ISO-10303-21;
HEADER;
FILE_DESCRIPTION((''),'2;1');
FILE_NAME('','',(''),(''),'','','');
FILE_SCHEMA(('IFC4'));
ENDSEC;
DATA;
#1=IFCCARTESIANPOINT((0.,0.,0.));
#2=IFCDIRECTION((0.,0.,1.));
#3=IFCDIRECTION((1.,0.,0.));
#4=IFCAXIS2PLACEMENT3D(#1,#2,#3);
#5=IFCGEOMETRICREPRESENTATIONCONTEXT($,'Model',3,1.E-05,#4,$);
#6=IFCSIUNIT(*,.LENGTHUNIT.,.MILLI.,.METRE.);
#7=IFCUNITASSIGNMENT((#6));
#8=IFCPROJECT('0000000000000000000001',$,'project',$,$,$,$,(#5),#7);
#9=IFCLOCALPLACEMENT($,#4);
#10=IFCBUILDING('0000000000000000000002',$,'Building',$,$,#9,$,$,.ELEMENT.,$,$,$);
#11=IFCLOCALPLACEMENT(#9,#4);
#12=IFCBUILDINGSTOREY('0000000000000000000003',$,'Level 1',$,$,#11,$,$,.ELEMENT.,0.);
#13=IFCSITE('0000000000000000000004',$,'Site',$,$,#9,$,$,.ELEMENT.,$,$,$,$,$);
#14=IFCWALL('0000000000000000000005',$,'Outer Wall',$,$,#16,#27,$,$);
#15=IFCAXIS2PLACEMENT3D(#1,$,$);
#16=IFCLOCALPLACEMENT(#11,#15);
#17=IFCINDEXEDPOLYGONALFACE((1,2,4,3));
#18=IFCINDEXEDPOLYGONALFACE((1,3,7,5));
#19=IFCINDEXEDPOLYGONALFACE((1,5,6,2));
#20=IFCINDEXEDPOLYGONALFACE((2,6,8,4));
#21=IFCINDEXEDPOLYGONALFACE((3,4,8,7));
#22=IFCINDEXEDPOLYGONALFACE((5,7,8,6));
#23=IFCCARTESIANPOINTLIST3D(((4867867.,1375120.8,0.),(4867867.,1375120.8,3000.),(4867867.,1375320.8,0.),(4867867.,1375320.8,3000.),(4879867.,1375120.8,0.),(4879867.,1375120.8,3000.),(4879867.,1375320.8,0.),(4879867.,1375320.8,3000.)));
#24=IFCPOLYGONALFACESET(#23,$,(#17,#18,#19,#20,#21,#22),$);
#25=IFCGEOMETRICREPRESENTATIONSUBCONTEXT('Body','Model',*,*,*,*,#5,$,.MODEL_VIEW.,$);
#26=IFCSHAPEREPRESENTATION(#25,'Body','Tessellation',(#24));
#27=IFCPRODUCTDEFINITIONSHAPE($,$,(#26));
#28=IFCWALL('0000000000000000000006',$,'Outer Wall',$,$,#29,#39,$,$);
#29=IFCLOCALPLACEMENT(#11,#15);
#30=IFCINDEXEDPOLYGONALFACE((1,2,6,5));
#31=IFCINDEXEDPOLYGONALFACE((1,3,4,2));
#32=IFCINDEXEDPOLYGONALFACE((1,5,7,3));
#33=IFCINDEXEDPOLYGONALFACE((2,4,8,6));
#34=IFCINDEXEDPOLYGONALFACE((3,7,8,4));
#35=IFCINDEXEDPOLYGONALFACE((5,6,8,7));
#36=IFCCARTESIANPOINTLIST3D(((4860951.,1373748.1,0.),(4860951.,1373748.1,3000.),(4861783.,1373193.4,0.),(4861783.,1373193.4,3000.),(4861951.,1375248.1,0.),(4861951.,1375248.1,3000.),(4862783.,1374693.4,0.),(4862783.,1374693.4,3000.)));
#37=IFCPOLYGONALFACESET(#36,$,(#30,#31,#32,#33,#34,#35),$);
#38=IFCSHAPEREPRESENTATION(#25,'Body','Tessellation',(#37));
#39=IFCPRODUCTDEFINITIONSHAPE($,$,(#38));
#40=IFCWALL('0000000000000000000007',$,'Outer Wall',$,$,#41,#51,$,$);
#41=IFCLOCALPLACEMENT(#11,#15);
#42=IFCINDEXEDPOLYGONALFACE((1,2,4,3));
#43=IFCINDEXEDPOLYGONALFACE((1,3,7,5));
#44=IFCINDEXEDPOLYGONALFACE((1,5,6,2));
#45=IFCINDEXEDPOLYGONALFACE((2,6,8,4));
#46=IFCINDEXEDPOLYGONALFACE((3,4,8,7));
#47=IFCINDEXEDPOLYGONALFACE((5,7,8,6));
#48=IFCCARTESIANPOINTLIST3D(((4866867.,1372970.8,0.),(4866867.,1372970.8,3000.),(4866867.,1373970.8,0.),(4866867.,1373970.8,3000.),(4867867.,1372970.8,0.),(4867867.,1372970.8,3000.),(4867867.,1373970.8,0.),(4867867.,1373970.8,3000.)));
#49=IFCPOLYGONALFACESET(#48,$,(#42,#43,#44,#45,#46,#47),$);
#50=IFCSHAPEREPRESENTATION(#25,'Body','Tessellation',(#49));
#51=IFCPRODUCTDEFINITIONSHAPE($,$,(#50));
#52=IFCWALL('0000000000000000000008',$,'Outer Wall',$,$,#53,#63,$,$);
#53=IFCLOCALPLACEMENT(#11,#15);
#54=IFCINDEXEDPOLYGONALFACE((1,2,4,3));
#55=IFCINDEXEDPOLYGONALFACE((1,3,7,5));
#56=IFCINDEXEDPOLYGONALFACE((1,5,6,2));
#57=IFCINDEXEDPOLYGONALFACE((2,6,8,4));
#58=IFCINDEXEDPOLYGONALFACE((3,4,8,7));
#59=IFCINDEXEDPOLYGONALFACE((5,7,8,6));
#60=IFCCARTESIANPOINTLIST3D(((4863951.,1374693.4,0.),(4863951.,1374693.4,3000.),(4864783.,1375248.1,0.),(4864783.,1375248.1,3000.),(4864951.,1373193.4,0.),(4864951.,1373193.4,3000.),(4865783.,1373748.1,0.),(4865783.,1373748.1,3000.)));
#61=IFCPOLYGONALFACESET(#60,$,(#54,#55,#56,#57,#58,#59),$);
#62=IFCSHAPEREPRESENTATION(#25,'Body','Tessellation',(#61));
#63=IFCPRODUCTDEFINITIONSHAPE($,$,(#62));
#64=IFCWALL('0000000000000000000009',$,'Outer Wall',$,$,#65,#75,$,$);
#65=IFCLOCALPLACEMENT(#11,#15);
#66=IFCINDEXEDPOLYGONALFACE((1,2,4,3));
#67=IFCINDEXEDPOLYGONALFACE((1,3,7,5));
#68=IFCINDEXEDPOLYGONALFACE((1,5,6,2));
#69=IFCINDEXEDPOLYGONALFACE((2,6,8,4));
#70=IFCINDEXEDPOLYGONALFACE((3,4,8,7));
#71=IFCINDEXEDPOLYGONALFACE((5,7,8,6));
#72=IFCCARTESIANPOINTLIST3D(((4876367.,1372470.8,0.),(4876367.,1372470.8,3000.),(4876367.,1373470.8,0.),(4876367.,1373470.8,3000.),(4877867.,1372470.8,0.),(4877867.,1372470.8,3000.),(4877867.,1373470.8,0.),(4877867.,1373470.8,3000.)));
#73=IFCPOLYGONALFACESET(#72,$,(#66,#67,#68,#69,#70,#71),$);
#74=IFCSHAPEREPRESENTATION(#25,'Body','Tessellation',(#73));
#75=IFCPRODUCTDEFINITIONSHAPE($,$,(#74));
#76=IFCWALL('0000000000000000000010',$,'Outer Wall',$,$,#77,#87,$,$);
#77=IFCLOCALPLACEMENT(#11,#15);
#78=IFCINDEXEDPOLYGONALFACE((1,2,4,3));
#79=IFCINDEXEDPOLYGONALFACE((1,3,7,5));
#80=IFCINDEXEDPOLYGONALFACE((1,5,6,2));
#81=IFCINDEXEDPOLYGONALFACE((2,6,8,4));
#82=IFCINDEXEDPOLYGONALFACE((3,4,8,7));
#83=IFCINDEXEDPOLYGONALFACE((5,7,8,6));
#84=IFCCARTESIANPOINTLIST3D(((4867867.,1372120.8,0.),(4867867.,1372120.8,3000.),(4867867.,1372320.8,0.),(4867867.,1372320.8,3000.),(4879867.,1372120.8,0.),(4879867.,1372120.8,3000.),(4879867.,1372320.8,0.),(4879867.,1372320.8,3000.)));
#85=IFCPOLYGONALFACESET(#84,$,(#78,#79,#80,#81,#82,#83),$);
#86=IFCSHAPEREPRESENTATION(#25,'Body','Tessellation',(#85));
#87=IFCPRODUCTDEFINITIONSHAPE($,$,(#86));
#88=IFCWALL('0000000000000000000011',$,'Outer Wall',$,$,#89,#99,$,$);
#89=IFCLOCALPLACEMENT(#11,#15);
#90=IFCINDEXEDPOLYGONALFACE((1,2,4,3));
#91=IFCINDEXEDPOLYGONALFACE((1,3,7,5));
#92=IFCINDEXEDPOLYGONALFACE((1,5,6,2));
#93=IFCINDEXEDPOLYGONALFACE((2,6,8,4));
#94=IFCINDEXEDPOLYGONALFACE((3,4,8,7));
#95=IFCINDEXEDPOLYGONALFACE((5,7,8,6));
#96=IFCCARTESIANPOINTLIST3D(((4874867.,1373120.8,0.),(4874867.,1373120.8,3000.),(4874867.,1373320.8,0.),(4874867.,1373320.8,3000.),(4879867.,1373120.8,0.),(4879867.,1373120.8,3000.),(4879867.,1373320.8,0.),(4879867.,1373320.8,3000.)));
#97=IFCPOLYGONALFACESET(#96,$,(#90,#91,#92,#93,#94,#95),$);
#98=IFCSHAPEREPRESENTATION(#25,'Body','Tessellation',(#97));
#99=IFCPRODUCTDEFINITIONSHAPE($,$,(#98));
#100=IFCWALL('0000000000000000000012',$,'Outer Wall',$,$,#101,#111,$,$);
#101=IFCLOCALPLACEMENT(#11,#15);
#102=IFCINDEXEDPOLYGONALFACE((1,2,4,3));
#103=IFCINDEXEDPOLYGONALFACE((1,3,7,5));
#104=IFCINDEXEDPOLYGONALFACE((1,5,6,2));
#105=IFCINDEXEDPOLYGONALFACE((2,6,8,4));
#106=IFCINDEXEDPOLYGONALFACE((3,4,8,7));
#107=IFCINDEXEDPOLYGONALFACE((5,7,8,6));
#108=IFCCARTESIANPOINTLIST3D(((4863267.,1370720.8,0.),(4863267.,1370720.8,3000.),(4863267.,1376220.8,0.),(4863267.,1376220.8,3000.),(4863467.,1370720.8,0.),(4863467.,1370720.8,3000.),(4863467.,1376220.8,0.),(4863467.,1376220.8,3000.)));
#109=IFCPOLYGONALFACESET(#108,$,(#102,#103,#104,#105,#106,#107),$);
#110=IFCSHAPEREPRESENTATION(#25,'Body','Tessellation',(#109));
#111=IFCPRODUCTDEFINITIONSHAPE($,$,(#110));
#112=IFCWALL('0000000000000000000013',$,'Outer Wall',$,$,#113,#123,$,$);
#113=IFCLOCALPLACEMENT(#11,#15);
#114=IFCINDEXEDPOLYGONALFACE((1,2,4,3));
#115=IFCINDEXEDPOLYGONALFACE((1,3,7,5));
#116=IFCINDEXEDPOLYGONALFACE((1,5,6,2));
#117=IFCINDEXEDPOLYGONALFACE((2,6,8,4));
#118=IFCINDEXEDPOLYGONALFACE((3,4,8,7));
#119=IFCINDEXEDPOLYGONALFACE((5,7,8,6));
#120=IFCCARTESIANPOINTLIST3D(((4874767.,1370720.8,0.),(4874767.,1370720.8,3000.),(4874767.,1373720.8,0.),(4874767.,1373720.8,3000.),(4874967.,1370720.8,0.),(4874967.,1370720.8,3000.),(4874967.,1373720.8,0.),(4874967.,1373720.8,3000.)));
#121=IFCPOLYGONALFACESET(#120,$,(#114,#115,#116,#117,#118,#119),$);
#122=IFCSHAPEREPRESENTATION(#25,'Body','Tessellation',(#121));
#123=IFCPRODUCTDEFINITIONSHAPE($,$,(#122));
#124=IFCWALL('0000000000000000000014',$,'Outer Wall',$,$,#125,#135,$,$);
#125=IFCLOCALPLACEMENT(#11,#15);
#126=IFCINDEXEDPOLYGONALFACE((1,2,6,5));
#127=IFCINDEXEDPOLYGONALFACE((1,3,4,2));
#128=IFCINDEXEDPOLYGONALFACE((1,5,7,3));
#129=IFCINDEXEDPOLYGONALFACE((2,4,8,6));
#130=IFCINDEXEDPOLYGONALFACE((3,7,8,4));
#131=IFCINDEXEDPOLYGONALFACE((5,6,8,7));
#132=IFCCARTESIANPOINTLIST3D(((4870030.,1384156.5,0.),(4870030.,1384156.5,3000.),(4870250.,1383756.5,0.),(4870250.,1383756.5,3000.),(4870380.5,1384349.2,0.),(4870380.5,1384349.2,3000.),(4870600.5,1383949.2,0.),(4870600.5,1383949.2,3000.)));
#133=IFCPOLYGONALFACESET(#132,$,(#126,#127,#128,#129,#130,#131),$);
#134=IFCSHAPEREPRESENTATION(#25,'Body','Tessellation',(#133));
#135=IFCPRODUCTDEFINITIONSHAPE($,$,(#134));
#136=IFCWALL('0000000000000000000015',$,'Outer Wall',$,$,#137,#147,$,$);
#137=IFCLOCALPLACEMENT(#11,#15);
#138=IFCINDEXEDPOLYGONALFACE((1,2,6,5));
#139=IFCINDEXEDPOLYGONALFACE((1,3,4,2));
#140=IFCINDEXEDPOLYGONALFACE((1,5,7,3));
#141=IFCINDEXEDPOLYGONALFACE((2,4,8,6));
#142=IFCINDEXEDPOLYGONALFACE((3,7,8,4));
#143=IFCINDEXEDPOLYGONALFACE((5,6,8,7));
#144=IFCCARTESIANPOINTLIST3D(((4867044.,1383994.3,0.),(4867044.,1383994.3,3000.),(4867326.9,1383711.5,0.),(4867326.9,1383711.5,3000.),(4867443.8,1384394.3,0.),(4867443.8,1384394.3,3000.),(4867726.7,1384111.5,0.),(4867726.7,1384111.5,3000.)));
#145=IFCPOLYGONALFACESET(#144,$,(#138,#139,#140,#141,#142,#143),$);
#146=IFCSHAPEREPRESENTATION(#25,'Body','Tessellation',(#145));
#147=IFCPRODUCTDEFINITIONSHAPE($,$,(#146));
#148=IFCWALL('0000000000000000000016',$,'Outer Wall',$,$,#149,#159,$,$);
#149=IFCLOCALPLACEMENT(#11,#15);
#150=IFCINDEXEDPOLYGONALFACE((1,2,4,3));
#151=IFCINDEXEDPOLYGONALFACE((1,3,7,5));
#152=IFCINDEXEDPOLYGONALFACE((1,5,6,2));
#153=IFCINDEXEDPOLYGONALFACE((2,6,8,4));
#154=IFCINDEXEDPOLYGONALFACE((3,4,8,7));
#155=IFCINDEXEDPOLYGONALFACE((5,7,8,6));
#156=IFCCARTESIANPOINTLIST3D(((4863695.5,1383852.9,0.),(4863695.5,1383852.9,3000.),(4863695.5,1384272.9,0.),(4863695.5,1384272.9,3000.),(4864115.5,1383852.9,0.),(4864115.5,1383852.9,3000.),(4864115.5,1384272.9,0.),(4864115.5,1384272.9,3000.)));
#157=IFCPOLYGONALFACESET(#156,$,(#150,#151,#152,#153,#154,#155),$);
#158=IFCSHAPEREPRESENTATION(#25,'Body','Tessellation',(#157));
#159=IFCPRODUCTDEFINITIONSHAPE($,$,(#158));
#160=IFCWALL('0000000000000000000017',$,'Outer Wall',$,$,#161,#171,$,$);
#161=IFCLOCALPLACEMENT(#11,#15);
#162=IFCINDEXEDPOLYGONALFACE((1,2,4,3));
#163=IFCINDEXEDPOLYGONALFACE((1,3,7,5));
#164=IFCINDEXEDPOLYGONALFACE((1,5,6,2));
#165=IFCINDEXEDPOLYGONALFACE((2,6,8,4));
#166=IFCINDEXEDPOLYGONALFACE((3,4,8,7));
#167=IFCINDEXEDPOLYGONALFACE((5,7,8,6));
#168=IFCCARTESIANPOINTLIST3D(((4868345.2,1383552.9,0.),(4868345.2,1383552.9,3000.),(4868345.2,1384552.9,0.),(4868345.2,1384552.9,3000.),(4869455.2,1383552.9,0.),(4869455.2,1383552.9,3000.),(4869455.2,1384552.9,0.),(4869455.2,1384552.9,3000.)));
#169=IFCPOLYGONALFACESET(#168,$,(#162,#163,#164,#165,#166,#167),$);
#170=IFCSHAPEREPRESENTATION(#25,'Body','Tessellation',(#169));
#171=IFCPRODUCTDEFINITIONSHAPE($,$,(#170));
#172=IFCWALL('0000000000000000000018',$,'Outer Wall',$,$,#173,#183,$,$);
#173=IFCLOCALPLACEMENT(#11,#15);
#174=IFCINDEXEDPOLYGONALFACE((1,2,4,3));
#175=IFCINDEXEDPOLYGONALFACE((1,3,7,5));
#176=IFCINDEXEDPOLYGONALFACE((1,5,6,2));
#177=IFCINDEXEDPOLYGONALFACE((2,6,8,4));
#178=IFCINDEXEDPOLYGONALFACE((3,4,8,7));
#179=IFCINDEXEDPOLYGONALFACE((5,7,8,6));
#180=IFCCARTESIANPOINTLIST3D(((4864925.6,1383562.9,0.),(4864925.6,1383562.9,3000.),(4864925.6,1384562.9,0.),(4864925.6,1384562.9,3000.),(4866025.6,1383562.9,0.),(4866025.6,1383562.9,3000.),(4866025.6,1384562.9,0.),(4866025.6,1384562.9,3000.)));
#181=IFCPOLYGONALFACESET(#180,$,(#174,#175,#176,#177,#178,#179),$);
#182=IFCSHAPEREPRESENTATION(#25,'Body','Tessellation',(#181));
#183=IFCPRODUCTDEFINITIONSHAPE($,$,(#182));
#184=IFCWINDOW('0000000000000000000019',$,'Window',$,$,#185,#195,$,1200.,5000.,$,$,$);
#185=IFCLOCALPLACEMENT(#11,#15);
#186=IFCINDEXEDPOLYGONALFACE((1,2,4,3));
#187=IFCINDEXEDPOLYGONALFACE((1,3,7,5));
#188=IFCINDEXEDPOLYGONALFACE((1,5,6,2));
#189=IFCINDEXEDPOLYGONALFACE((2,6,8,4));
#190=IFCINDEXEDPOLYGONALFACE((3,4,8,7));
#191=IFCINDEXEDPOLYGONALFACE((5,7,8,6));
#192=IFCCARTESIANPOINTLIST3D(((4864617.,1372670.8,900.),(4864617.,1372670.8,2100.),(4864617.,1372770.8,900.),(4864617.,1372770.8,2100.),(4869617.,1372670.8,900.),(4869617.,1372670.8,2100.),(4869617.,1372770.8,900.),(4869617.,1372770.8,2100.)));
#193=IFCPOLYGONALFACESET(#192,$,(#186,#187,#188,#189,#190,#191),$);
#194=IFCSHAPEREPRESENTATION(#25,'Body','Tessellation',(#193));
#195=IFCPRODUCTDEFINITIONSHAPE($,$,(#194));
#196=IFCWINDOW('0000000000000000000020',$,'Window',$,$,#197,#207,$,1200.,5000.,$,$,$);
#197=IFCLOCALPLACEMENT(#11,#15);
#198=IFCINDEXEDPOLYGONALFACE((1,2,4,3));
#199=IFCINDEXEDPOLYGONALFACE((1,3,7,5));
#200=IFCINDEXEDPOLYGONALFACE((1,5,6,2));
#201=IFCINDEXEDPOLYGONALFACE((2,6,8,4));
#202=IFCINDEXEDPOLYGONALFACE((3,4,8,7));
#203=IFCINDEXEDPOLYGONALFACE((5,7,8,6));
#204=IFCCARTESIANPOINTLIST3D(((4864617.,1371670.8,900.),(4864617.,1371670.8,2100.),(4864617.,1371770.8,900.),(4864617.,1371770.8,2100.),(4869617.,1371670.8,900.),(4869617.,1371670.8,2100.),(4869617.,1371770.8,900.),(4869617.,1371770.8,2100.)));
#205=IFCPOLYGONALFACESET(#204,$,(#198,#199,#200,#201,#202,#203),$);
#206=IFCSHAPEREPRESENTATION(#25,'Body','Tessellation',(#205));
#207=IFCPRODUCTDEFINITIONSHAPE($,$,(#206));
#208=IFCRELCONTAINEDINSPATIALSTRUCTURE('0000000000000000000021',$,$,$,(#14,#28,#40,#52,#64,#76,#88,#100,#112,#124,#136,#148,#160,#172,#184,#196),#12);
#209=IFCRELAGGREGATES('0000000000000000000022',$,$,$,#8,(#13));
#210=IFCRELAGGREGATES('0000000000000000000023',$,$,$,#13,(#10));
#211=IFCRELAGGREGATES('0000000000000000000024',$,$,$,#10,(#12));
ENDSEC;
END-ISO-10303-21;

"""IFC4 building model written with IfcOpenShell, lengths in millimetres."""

from ifc_helpers import new_model, si_unit, frame, frame_2d, origin_with_axes, place, context, subcontext, project, spatial, rectangle, extrude, element, save


model = new_model("IFC4")

# Units and contexts
model_context = context("Model", 3, precision=1e-05, world=origin_with_axes())
body_context = subcontext(model_context, "Body", "Model", "MODEL_VIEW")
ifc_project = project(units=[si_unit("LENGTHUNIT", "METRE", prefix="MILLI")], contexts=[model_context])

# Site, building, storey
placement = place(None, origin_with_axes())
site = spatial("IfcSite", under=ifc_project, at=placement, Name="Site", CompositionType="ELEMENT")
building = spatial("IfcBuilding", under=site, at=placement, Name="Building", CompositionType="ELEMENT")
storey_placement = place(placement, origin_with_axes())
storey = spatial("IfcBuildingStorey", under=building, at=storey_placement, Name="Level 1", CompositionType="ELEMENT", Elevation=0.0)

# Walls
wall_1_placement = place(placement, frame((4867867.0, 1375220.8, 0.0), z_axis=(0.0, 0.0, 1.0), x_axis=(1.0, 0.0, 0.0)))
element("IfcWall", 1, at=wall_1_placement, inside=storey, Name="Outer Wall", context=body_context, shape_type="SweptSolid", body=[
    extrude(rectangle(XDim=12000.0, YDim=200.0, at=frame_2d((6000.0, 0.0), x_axis=(1.0, 0.0))), origin_with_axes(), (0.0, 0.0, 1.0), 3000.0),
])
wall_2_placement = place(placement, frame((4862367.0, 1374970.8, 0.0), z_axis=(0.0, 0.0, 1.0), x_axis=(-0.5547, -0.83205, 0.0)))
element("IfcWall", 2, at=wall_2_placement, inside=storey, Name="Outer Wall", context=body_context, shape_type="SweptSolid", body=[
    extrude(rectangle(XDim=1802.8, YDim=1000.0, at=frame_2d((901.4, 0.0), x_axis=(1.0, 0.0))), origin_with_axes(), (0.0, 0.0, 1.0), 3000.0),
])
wall_3_placement = place(placement, frame((4866867.0, 1373470.8, 0.0), z_axis=(0.0, 0.0, 1.0), x_axis=(1.0, 0.0, 0.0)))
element("IfcWall", 3, at=wall_3_placement, inside=storey, Name="Outer Wall", context=body_context, shape_type="SweptSolid", body=[
    extrude(rectangle(XDim=1000.0, YDim=1000.0, at=frame_2d((500.0, 0.0), x_axis=(1.0, 0.0))), origin_with_axes(), (0.0, 0.0, 1.0), 3000.0),
])
wall_4_placement = place(placement, frame((4865367.0, 1373470.8, 0.0), z_axis=(0.0, 0.0, 1.0), x_axis=(-0.5547, 0.83205, 0.0)))
element("IfcWall", 4, at=wall_4_placement, inside=storey, Name="Outer Wall", context=body_context, shape_type="SweptSolid", body=[
    extrude(rectangle(XDim=1802.8, YDim=1000.0, at=frame_2d((901.4, 0.0), x_axis=(1.0, 0.0))), origin_with_axes(), (0.0, 0.0, 1.0), 3000.0),
])
wall_5_placement = place(placement, frame((4877867.0, 1372970.8, 0.0), z_axis=(0.0, 0.0, 1.0), x_axis=(-1.0, 0.0, 0.0)))
element("IfcWall", 5, at=wall_5_placement, inside=storey, Name="Outer Wall", context=body_context, shape_type="SweptSolid", body=[
    extrude(rectangle(XDim=1500.0, YDim=1000.0, at=frame_2d((750.0, 0.0), x_axis=(1.0, 0.0))), origin_with_axes(), (0.0, 0.0, 1.0), 3000.0),
])
wall_6_placement = place(placement, frame((4867867.0, 1372220.8, 0.0), z_axis=(0.0, 0.0, 1.0), x_axis=(1.0, 0.0, 0.0)))
element("IfcWall", 6, at=wall_6_placement, inside=storey, Name="Outer Wall", context=body_context, shape_type="SweptSolid", body=[
    extrude(rectangle(XDim=12000.0, YDim=200.0, at=frame_2d((6000.0, 0.0), x_axis=(1.0, 0.0))), origin_with_axes(), (0.0, 0.0, 1.0), 3000.0),
])
wall_7_placement = place(placement, frame((4874867.0, 1373220.8, 0.0), z_axis=(0.0, 0.0, 1.0), x_axis=(1.0, 0.0, 0.0)))
element("IfcWall", 7, at=wall_7_placement, inside=storey, Name="Outer Wall", context=body_context, shape_type="SweptSolid", body=[
    extrude(rectangle(XDim=5000.0, YDim=200.0, at=frame_2d((2500.0, 0.0), x_axis=(1.0, 0.0))), origin_with_axes(), (0.0, 0.0, 1.0), 3000.0),
])
wall_8_placement = place(placement, frame((4863367.0, 1370720.8, 0.0), z_axis=(0.0, 0.0, 1.0), x_axis=(0.0, 1.0, 0.0)))
element("IfcWall", 8, at=wall_8_placement, inside=storey, Name="Outer Wall", context=body_context, shape_type="SweptSolid", body=[
    extrude(rectangle(XDim=5500.0, YDim=200.0, at=frame_2d((2750.0, 0.0), x_axis=(1.0, 0.0))), origin_with_axes(), (0.0, 0.0, 1.0), 3000.0),
])
wall_9_placement = place(placement, frame((4874867.0, 1373720.8, 0.0), z_axis=(0.0, 0.0, 1.0), x_axis=(0.0, -1.0, 0.0)))
element("IfcWall", 9, at=wall_9_placement, inside=storey, Name="Outer Wall", context=body_context, shape_type="SweptSolid", body=[
    extrude(rectangle(XDim=3000.0, YDim=200.0, at=frame_2d((1500.0, 0.0), x_axis=(1.0, 0.0))), origin_with_axes(), (0.0, 0.0, 1.0), 3000.0),
])
wall_10_placement = place(placement, frame((4870205.2, 1384252.9, 0.0), z_axis=(0.0, 0.0, 1.0), x_axis=(0.481919, -0.876216, 0.0)))
element("IfcWall", 10, at=wall_10_placement, inside=storey, Name="Outer Wall", context=body_context, shape_type="SweptSolid", body=[
    extrude(rectangle(XDim=456.5, YDim=400.0, at=frame_2d((228.3, 0.0), x_axis=(1.0, 0.0))), origin_with_axes(), (0.0, 0.0, 1.0), 3000.0),
])
wall_11_placement = place(placement, frame((4867585.2, 1384252.9, 0.0), z_axis=(0.0, 0.0, 1.0), x_axis=(-0.706947, -0.707266, 0.0)))
element("IfcWall", 11, at=wall_11_placement, inside=storey, Name="Outer Wall", context=body_context, shape_type="SweptSolid", body=[
    extrude(rectangle(XDim=565.6, YDim=400.0, at=frame_2d((282.8, 0.0), x_axis=(1.0, 0.0))), origin_with_axes(), (0.0, 0.0, 1.0), 3000.0),
])
wall_12_placement = place(placement, frame((4863905.5, 1384272.9, 0.0), z_axis=(0.0, 0.0, 1.0), x_axis=(0.0, -1.0, 0.0)))
element("IfcWall", 12, at=wall_12_placement, inside=storey, Name="Outer Wall", context=body_context, shape_type="SweptSolid", body=[
    extrude(rectangle(XDim=420.0, YDim=420.0, at=frame_2d((210.0, 0.0), x_axis=(1.0, 0.0))), origin_with_axes(), (0.0, 0.0, 1.0), 3000.0),
])
wall_13_placement = place(placement, frame((4868345.2, 1384052.9, 0.0), z_axis=(0.0, 0.0, 1.0), x_axis=(1.0, 0.0, 0.0)))
element("IfcWall", 13, at=wall_13_placement, inside=storey, Name="Outer Wall", context=body_context, shape_type="SweptSolid", body=[
    extrude(rectangle(XDim=1110.0, YDim=1000.0, at=frame_2d((555.0, 0.0), x_axis=(1.0, 0.0))), origin_with_axes(), (0.0, 0.0, 1.0), 3000.0),
])
wall_14_placement = place(placement, frame((4864925.6, 1384062.9, 0.0), z_axis=(0.0, 0.0, 1.0), x_axis=(1.0, 0.0, 0.0)))
element("IfcWall", 14, at=wall_14_placement, inside=storey, Name="Outer Wall", context=body_context, shape_type="SweptSolid", body=[
    extrude(rectangle(XDim=1100.0, YDim=1000.0, at=frame_2d((550.0, 0.0), x_axis=(1.0, 0.0))), origin_with_axes(), (0.0, 0.0, 1.0), 3000.0),
])

# Windows
for number, where, z_axis, x_axis, name in (
    (15, (4864617.0, 1372720.8, 900.0), (0.0, 0.0, 1.0), (1.0, 0.0, 0.0), "Window"),
    (16, (4864617.0, 1371720.8, 900.0), (0.0, 0.0, 1.0), (1.0, 0.0, 0.0), "Window"),
):
    element("IfcWindow", number, at=place(placement, frame(where, z_axis=z_axis, x_axis=x_axis)), inside=storey, Name=name, OverallHeight=1200.0, OverallWidth=5000.0, context=body_context, shape_type="SweptSolid", body=[
        extrude(rectangle(XDim=5000.0, YDim=100.0, at=frame_2d((2500.0, 0.0), x_axis=(1.0, 0.0))), origin_with_axes(), (0.0, 0.0, 1.0), 1200.0),
    ])

save(model, "model.ifc")
